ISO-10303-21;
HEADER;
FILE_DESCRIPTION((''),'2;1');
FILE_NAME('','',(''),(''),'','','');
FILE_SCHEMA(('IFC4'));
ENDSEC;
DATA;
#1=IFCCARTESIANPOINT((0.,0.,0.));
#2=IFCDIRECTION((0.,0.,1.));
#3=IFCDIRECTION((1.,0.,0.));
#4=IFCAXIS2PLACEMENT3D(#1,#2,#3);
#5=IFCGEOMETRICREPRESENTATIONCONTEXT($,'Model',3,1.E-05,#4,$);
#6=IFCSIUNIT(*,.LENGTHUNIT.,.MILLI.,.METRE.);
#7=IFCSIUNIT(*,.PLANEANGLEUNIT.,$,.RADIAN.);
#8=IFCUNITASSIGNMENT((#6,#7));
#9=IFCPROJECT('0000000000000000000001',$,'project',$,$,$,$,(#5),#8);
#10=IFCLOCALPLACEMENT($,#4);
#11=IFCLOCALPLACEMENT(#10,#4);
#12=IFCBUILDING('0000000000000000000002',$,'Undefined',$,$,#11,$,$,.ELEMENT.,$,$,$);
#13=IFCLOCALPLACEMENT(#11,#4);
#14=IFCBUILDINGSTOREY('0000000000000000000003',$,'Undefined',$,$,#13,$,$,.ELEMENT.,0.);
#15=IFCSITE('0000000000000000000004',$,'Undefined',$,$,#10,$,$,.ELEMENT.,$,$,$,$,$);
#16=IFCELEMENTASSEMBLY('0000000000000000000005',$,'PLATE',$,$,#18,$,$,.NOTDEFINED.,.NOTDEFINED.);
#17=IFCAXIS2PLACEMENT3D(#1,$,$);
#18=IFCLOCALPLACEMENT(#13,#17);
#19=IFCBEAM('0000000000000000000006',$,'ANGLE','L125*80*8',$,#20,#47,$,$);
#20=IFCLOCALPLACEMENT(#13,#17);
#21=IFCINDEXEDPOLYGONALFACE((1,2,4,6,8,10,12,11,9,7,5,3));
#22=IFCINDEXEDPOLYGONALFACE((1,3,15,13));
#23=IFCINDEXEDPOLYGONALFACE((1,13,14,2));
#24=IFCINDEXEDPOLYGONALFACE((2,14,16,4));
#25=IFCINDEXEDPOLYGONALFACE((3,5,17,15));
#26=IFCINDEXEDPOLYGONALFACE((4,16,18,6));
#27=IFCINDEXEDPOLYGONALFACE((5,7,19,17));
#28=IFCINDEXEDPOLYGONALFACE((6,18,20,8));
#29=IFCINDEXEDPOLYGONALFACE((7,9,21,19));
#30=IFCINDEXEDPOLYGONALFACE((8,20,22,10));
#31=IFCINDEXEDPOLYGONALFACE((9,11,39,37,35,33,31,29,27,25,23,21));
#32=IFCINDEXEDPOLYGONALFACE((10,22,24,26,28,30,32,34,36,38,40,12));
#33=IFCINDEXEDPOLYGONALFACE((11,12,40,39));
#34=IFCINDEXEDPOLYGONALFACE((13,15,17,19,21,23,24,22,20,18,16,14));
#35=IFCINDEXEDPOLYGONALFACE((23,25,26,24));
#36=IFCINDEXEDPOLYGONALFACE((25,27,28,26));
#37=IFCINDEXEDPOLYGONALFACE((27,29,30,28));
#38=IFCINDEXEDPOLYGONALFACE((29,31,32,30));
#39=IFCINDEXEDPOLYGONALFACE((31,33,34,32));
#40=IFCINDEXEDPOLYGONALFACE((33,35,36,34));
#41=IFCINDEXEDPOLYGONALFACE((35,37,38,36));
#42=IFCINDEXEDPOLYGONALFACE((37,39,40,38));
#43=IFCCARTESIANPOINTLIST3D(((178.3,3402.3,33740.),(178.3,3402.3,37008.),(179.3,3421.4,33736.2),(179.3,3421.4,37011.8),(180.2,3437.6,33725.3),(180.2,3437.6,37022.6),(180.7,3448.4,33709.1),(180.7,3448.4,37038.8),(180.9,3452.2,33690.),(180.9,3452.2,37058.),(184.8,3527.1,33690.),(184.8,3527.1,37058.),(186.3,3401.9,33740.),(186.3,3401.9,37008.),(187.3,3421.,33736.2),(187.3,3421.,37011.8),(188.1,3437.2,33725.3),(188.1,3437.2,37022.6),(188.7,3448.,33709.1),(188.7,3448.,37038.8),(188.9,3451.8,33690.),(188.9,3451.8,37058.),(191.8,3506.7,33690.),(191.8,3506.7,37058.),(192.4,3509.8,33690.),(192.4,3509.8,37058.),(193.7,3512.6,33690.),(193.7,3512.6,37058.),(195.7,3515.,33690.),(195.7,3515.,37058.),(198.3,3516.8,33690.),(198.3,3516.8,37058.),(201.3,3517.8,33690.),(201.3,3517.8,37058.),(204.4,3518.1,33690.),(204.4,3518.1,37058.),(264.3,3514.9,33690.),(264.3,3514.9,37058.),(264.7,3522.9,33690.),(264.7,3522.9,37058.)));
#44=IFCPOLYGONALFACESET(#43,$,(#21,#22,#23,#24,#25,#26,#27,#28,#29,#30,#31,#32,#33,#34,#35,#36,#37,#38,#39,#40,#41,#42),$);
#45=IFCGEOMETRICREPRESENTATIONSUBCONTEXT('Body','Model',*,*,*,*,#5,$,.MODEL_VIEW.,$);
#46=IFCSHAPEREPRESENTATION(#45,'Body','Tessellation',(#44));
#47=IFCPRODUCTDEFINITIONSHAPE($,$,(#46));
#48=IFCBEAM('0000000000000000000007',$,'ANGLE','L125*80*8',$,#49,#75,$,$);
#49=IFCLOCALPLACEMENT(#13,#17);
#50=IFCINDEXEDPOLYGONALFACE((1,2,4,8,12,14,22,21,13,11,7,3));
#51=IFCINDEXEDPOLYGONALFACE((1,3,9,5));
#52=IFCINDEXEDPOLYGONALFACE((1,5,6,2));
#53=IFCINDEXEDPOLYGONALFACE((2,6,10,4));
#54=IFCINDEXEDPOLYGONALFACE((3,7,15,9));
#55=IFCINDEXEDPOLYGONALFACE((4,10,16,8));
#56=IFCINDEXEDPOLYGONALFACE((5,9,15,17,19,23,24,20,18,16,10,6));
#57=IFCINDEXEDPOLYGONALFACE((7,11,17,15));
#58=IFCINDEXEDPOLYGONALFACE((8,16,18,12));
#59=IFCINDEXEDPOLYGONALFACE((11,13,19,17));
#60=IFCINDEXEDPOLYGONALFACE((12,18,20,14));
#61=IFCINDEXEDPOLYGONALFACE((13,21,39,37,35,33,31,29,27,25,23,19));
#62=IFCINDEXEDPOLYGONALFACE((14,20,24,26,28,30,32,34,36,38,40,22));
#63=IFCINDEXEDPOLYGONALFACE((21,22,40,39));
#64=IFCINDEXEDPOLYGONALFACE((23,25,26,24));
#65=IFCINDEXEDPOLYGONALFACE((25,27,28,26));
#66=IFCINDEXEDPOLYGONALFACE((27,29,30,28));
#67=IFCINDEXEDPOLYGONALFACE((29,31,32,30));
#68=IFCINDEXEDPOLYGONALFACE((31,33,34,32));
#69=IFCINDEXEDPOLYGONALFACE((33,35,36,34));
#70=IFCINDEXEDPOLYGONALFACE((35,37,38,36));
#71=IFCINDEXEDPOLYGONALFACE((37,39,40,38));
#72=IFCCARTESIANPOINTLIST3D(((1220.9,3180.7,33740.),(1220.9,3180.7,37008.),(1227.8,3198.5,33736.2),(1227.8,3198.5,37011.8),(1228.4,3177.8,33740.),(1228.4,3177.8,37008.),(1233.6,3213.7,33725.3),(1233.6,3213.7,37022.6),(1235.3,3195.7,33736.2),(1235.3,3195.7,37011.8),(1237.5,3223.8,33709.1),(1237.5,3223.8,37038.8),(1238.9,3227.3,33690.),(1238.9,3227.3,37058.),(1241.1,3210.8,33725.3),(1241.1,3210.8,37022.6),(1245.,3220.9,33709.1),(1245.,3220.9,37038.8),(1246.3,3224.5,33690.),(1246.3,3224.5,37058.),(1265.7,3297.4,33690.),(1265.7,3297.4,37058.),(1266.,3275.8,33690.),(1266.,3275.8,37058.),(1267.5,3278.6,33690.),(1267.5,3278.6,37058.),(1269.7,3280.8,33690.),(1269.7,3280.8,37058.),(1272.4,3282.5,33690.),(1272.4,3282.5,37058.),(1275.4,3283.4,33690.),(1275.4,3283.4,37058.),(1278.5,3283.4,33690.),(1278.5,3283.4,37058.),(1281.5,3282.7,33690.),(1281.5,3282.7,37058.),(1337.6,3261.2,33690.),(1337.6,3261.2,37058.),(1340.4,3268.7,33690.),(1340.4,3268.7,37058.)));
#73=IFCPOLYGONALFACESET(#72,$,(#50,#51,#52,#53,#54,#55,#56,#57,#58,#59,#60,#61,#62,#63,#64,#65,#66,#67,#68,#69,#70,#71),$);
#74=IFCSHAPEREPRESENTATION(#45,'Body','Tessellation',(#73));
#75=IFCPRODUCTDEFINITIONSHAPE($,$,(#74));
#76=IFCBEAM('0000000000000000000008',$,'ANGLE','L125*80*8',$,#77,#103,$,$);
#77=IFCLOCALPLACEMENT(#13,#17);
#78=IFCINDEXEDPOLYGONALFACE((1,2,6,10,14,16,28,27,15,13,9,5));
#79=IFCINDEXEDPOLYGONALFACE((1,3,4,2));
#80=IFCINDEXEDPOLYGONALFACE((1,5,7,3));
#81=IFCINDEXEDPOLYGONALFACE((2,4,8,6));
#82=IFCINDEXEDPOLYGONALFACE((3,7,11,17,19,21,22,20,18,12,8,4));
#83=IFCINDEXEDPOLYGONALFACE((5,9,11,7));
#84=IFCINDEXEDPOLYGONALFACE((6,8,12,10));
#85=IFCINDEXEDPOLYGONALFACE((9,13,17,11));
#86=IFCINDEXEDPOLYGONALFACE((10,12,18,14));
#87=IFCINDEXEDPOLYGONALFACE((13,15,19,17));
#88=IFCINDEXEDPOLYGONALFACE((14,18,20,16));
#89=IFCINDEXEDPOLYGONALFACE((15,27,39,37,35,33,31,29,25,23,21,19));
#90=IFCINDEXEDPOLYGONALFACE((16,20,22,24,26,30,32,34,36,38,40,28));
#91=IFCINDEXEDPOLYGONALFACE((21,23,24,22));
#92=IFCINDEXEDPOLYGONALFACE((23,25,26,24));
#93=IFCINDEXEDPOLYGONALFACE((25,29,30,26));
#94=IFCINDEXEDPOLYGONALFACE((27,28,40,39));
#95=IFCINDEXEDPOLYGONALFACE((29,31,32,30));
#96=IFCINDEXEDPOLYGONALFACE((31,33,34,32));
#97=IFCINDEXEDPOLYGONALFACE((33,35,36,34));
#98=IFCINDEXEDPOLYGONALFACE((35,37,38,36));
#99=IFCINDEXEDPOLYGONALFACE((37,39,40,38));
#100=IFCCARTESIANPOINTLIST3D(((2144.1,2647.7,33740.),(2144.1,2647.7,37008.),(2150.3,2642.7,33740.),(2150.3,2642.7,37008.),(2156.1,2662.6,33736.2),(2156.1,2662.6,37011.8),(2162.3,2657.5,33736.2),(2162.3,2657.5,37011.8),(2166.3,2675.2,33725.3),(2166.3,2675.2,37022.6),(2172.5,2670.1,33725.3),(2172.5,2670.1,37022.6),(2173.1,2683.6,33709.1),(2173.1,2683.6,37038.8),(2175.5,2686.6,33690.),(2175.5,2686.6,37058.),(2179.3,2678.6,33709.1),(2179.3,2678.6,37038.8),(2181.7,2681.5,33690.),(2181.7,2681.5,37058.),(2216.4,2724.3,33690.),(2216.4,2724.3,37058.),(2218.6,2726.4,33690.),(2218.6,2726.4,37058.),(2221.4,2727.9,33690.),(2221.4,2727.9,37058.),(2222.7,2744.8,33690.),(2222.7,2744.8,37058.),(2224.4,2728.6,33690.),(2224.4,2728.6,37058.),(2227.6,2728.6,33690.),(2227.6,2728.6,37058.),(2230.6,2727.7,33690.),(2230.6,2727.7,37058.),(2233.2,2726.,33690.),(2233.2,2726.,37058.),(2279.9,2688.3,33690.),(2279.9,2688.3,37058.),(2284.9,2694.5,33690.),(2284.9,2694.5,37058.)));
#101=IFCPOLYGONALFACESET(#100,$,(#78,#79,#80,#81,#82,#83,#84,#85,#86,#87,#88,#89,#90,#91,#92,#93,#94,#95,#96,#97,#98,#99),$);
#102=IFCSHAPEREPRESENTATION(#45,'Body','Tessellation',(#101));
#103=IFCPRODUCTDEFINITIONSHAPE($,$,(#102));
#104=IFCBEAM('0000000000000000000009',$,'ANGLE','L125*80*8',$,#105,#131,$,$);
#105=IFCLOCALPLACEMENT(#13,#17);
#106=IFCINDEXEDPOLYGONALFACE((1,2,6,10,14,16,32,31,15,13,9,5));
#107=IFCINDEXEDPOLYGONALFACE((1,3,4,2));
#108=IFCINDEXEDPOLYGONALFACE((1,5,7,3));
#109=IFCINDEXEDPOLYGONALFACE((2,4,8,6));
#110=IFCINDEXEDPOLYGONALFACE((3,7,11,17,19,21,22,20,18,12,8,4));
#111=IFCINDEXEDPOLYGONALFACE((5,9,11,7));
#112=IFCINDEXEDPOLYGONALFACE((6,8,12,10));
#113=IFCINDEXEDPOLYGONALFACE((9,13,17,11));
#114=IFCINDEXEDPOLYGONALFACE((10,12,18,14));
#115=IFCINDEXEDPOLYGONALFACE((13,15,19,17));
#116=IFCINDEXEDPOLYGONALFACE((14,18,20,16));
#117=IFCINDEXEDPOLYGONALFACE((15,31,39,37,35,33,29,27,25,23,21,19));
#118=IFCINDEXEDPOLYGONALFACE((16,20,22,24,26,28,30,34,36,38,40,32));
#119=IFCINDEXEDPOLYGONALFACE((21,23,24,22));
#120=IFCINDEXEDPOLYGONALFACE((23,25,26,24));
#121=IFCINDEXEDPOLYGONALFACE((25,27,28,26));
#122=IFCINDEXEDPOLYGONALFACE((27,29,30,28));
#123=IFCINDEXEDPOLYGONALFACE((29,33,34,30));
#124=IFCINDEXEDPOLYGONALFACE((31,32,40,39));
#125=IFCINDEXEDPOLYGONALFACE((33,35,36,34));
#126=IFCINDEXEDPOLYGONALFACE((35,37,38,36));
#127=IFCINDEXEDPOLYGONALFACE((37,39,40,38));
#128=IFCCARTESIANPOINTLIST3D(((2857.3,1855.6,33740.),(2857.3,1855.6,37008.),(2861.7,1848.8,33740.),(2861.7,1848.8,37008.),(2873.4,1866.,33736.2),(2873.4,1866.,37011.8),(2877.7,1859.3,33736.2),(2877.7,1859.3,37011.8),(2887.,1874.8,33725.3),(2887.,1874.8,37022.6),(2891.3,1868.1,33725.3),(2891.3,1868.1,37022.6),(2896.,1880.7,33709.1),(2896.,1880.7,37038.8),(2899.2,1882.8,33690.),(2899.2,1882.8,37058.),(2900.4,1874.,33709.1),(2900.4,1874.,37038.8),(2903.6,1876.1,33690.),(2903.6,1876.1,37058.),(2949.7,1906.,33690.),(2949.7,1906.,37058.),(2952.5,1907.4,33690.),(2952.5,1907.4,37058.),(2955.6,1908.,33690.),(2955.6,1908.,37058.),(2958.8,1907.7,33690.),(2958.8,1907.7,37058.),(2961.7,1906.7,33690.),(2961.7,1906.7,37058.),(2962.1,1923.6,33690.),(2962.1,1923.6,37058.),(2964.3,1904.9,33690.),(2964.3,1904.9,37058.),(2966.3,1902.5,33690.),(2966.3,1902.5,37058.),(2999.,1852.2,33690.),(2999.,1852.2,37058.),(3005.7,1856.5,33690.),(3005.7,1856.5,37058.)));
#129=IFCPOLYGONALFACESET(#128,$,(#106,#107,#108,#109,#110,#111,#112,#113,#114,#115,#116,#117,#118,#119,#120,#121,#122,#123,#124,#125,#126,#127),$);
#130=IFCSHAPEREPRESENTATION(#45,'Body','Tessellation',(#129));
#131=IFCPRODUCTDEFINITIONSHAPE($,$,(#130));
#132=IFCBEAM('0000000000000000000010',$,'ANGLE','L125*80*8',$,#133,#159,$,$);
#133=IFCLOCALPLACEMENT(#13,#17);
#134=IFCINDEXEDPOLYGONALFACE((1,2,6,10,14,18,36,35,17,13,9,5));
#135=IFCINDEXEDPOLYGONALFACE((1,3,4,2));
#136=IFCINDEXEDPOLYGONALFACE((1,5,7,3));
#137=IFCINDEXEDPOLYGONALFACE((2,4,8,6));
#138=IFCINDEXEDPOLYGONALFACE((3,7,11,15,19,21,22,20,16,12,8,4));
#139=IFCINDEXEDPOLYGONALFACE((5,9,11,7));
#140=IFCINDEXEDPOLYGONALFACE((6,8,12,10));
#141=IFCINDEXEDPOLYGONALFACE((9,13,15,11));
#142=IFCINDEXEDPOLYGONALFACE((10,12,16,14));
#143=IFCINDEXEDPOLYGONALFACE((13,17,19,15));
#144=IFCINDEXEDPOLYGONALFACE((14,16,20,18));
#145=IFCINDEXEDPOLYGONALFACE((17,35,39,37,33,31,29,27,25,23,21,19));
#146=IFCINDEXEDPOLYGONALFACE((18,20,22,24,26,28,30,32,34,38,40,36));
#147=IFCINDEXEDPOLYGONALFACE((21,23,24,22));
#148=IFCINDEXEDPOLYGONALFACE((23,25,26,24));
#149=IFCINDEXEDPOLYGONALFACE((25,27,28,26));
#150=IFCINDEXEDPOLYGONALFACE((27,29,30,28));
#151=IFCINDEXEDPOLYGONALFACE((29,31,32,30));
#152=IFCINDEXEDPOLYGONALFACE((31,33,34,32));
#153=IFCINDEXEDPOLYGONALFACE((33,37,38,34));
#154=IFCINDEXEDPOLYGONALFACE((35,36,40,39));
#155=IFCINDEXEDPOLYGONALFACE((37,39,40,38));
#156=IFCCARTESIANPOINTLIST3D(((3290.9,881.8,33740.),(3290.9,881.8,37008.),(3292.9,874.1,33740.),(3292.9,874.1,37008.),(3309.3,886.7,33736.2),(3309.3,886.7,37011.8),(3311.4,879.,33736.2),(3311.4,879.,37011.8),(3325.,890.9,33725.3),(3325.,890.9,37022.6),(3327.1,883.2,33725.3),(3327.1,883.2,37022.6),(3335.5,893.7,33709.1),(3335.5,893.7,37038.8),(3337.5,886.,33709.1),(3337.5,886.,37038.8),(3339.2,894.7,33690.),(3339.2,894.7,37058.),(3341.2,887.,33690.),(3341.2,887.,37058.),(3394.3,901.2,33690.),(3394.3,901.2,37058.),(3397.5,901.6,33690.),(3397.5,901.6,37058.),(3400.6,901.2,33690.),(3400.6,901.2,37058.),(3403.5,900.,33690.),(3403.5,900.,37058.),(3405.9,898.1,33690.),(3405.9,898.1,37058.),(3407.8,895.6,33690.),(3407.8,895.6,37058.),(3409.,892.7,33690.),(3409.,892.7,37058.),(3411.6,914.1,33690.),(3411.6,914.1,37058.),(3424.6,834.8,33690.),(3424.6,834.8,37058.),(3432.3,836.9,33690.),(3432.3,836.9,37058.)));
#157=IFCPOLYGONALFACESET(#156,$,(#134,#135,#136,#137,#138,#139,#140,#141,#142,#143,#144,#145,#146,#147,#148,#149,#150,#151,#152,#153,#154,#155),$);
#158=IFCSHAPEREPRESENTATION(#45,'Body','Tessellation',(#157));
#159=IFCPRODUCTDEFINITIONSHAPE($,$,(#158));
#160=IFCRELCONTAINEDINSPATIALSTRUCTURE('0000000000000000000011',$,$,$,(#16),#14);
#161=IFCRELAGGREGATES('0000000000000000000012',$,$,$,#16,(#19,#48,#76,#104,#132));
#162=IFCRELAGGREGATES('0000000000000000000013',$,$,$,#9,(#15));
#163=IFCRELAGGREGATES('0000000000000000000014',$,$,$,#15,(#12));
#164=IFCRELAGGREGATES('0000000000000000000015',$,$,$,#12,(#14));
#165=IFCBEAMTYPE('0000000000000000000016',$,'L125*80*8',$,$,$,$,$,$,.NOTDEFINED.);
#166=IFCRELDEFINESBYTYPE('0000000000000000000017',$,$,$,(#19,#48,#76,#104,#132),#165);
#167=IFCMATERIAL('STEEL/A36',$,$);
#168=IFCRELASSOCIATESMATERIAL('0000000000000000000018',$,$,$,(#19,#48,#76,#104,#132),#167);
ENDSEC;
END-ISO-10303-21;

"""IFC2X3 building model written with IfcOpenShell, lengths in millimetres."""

from ifc_helpers import new_model, si_unit, frame, origin_with_axes, origin_2d_with_axis, place, context, subcontext, project, spatial, polyline, l_section, outline, extrude, boolean, material, type_object, element, aggregate, save


model = new_model("IFC2X3")

# Units and contexts
model_context = context("Model", 3, precision=1e-05, world=origin_with_axes())
body_context = subcontext(model_context, "Body", "Model", "MODEL_VIEW")
ifc_project = project(units=[si_unit("LENGTHUNIT", "METRE", prefix="MILLI"), si_unit("PLANEANGLEUNIT", "RADIAN")], contexts=[model_context])

# Site, building, storey
site_placement = place(None, origin_with_axes())
site = spatial("IfcSite", under=ifc_project, at=site_placement, Name="Undefined", CompositionType="ELEMENT")
building_placement = place(site_placement, origin_with_axes())
building = spatial("IfcBuilding", under=site, at=building_placement, Name="Undefined", CompositionType="ELEMENT")
storey_placement = place(building_placement, origin_with_axes())
storey = spatial("IfcBuildingStorey", under=building, at=storey_placement, Name="Undefined", CompositionType="ELEMENT", Elevation=0.0)

# Element assembly, beams
assembly_1_placement = place(storey_placement, origin_with_axes())
assembly_1 = element("IfcElementAssembly", 1, at=assembly_1_placement, inside=storey, Name="PLATE", AssemblyPlace="NOTDEFINED", PredefinedType="NOTDEFINED")
ifc_material_1 = material(Name="STEEL/A36")
beam_type = type_object("IfcBeamType", Name="L125*80*8", PredefinedType="NOTDEFINED")
beam_1_placement = place(assembly_1_placement, frame((221.5, 3462.6, 33690.0), z_axis=(-0.052336, -0.99863, 0.0), x_axis=(0.0, 0.0, 1.0)))
beam_1 = element("IfcBeam", 2, at=beam_1_placement, type_object=beam_type, material=ifc_material_1, Name="ANGLE", Description="L125*80*8", context=body_context, shape_type="CSG", body=[
    boolean("DIFFERENCE", boolean("DIFFERENCE", extrude(l_section(Depth=125.0, Width=80.0, Thickness=8.0, FilletRadius=12.0, at=origin_2d_with_axis()), frame((3368.0, 0.0, 0.0), z_axis=(-1.0, 0.0, 0.0), x_axis=(0.0, -1.0, 0.0)), (0.0, 0.0, 1.0), 3368.0), extrude(outline(polyline([(0.0, 0.0), (50.0, 0.0), (50.0, 0.0), (46.2, 19.1), (35.4, 35.4), (19.1, 46.2), (0.0, 50.0), (0.0, 50.0), (0.0, 0.0)])), frame((0.0, -38.0, 62.5), z_axis=(0.0, 1.0, 0.0), x_axis=(1.0, 0.0, 0.0)), (0.0, 0.0, 1.0), 81.0)), extrude(outline(polyline([(0.0, 0.0), (50.0, 0.0), (50.0, 0.0), (46.2, 19.1), (35.4, 35.4), (19.1, 46.2), (0.0, 50.0), (0.0, 50.0), (0.0, 0.0)])), frame((3368.0, -38.0, 62.5), z_axis=(0.0, 1.0, 0.0), x_axis=(-0.000152, -0.000001, -1.0)), (0.0, 0.0, 1.0), 81.0)),
])
beam_2_placement = place(assembly_1_placement, frame((1280.7, 3224.7, 33690.0), z_axis=(-0.358368, -0.93358, 0.0), x_axis=(0.0, 0.0, 1.0)))
beam_2 = element("IfcBeam", 3, at=beam_2_placement, type_object=beam_type, material=ifc_material_1, Name="ANGLE", Description="L125*80*8", context=body_context, shape_type="CSG", body=[
    boolean("DIFFERENCE", boolean("DIFFERENCE", extrude(l_section(Depth=125.0, Width=80.0, Thickness=8.0, FilletRadius=12.0, at=origin_2d_with_axis()), frame((3368.0, 0.0, 0.0), z_axis=(-1.0, 0.0, 0.0), x_axis=(0.0, -1.0, 0.0)), (0.0, 0.0, 1.0), 3368.0), extrude(outline(polyline([(0.0, 0.0), (50.0, 0.0), (50.0, 0.0), (46.2, 19.1), (35.4, 35.4), (19.1, 46.2), (0.0, 50.0), (0.0, 50.0), (0.0, 0.0)])), frame((0.0, -38.0, 62.5), z_axis=(0.0, 1.0, 0.0), x_axis=(1.0, 0.0, 0.0)), (0.0, 0.0, 1.0), 81.0)), extrude(outline(polyline([(0.0, 0.0), (50.0, 0.0), (50.0, 0.0), (46.2, 19.1), (35.4, 35.4), (19.1, 46.2), (0.0, 50.0), (0.0, 50.0), (0.0, 0.0)])), frame((3368.0, -38.0, 62.5), z_axis=(0.0, 1.0, 0.0), x_axis=(-0.000152, -0.000001, -1.0)), (0.0, 0.0, 1.0), 81.0)),
])
beam_3_placement = place(assembly_1_placement, frame((2214.5, 2671.1, 33690.0), z_axis=(-0.62932, -0.777146, 0.0), x_axis=(0.0, 0.0, 1.0)))
beam_3 = element("IfcBeam", 4, at=beam_3_placement, type_object=beam_type, material=ifc_material_1, Name="ANGLE", Description="L125*80*8", context=body_context, shape_type="CSG", body=[
    boolean("DIFFERENCE", boolean("DIFFERENCE", extrude(l_section(Depth=125.0, Width=80.0, Thickness=8.0, FilletRadius=12.0, at=origin_2d_with_axis()), frame((3368.0, 0.0, 0.0), z_axis=(-1.0, 0.0, 0.0), x_axis=(0.0, -1.0, 0.0)), (0.0, 0.0, 1.0), 3368.0), extrude(outline(polyline([(0.0, 0.0), (50.0, 0.0), (50.0, 0.0), (46.2, 19.1), (35.4, 35.4), (19.1, 46.2), (0.0, 50.0), (0.0, 50.0), (0.0, 0.0)])), frame((0.0, -38.0, 62.5), z_axis=(0.0, 1.0, 0.0), x_axis=(1.0, 0.0, 0.0)), (0.0, 0.0, 1.0), 81.0)), extrude(outline(polyline([(0.0, 0.0), (50.0, 0.0), (50.0, 0.0), (46.2, 19.1), (35.4, 35.4), (19.1, 46.2), (0.0, 50.0), (0.0, 50.0), (0.0, 0.0)])), frame((3368.0, -38.0, 62.5), z_axis=(0.0, 1.0, 0.0), x_axis=(-0.000152, -0.000001, -1.0)), (0.0, 0.0, 1.0), 81.0)),
])
beam_4_placement = place(assembly_1_placement, frame((2931.5, 1856.0, 33690.0), z_axis=(-0.838671, -0.544639, 0.0), x_axis=(0.0, 0.0, 1.0)))
beam_4 = element("IfcBeam", 5, at=beam_4_placement, type_object=beam_type, material=ifc_material_1, Name="ANGLE", Description="L125*80*8", context=body_context, shape_type="CSG", body=[
    boolean("DIFFERENCE", boolean("DIFFERENCE", extrude(l_section(Depth=125.0, Width=80.0, Thickness=8.0, FilletRadius=12.0, at=origin_2d_with_axis()), frame((3368.0, 0.0, 0.0), z_axis=(-1.0, 0.0, 0.0), x_axis=(0.0, -1.0, 0.0)), (0.0, 0.0, 1.0), 3368.0), extrude(outline(polyline([(0.0, 0.0), (50.0, 0.0), (50.0, 0.0), (46.2, 19.1), (35.4, 35.4), (19.1, 46.2), (0.0, 50.0), (0.0, 50.0), (0.0, 0.0)])), frame((0.0, -38.0, 62.5), z_axis=(0.0, 1.0, 0.0), x_axis=(1.0, 0.0, 0.0)), (0.0, 0.0, 1.0), 81.0)), extrude(outline(polyline([(0.0, 0.0), (50.0, 0.0), (50.0, 0.0), (46.2, 19.1), (35.4, 35.4), (19.1, 46.2), (0.0, 50.0), (0.0, 50.0), (0.0, 0.0)])), frame((3368.0, -38.0, 62.5), z_axis=(0.0, 1.0, 0.0), x_axis=(-0.000152, -0.000001, -1.0)), (0.0, 0.0, 1.0), 81.0)),
])
beam_5_placement = place(assembly_1_placement, frame((3361.6, 859.3, 33690.0), z_axis=(-0.965926, -0.258819, 0.0), x_axis=(0.0, 0.0, 1.0)))
beam_5 = element("IfcBeam", 6, at=beam_5_placement, type_object=beam_type, material=ifc_material_1, Name="ANGLE", Description="L125*80*8", context=body_context, shape_type="CSG", body=[
    boolean("DIFFERENCE", boolean("DIFFERENCE", extrude(l_section(Depth=125.0, Width=80.0, Thickness=8.0, FilletRadius=12.0, at=origin_2d_with_axis()), frame((3368.0, 0.0, 0.0), z_axis=(-1.0, 0.0, 0.0), x_axis=(0.0, -1.0, 0.0)), (0.0, 0.0, 1.0), 3368.0), extrude(outline(polyline([(0.0, 0.0), (50.0, 0.0), (50.0, 0.0), (46.2, 19.1), (35.4, 35.4), (19.1, 46.2), (0.0, 50.0), (0.0, 50.0), (0.0, 0.0)])), frame((0.0, -38.0, 62.5), z_axis=(0.0, 1.0, 0.0), x_axis=(1.0, 0.0, 0.0)), (0.0, 0.0, 1.0), 81.0)), extrude(outline(polyline([(0.0, 0.0), (50.0, 0.0), (50.0, 0.0), (46.2, 19.1), (35.4, 35.4), (19.1, 46.2), (0.0, 50.0), (0.0, 50.0), (0.0, 0.0)])), frame((3368.0, -38.0, 62.5), z_axis=(0.0, 1.0, 0.0), x_axis=(-0.000152, -0.000001, -1.0)), (0.0, 0.0, 1.0), 81.0)),
])
aggregate(assembly_1, [beam_1, beam_2, beam_3, beam_4, beam_5])

save(model, "model.ifc")
